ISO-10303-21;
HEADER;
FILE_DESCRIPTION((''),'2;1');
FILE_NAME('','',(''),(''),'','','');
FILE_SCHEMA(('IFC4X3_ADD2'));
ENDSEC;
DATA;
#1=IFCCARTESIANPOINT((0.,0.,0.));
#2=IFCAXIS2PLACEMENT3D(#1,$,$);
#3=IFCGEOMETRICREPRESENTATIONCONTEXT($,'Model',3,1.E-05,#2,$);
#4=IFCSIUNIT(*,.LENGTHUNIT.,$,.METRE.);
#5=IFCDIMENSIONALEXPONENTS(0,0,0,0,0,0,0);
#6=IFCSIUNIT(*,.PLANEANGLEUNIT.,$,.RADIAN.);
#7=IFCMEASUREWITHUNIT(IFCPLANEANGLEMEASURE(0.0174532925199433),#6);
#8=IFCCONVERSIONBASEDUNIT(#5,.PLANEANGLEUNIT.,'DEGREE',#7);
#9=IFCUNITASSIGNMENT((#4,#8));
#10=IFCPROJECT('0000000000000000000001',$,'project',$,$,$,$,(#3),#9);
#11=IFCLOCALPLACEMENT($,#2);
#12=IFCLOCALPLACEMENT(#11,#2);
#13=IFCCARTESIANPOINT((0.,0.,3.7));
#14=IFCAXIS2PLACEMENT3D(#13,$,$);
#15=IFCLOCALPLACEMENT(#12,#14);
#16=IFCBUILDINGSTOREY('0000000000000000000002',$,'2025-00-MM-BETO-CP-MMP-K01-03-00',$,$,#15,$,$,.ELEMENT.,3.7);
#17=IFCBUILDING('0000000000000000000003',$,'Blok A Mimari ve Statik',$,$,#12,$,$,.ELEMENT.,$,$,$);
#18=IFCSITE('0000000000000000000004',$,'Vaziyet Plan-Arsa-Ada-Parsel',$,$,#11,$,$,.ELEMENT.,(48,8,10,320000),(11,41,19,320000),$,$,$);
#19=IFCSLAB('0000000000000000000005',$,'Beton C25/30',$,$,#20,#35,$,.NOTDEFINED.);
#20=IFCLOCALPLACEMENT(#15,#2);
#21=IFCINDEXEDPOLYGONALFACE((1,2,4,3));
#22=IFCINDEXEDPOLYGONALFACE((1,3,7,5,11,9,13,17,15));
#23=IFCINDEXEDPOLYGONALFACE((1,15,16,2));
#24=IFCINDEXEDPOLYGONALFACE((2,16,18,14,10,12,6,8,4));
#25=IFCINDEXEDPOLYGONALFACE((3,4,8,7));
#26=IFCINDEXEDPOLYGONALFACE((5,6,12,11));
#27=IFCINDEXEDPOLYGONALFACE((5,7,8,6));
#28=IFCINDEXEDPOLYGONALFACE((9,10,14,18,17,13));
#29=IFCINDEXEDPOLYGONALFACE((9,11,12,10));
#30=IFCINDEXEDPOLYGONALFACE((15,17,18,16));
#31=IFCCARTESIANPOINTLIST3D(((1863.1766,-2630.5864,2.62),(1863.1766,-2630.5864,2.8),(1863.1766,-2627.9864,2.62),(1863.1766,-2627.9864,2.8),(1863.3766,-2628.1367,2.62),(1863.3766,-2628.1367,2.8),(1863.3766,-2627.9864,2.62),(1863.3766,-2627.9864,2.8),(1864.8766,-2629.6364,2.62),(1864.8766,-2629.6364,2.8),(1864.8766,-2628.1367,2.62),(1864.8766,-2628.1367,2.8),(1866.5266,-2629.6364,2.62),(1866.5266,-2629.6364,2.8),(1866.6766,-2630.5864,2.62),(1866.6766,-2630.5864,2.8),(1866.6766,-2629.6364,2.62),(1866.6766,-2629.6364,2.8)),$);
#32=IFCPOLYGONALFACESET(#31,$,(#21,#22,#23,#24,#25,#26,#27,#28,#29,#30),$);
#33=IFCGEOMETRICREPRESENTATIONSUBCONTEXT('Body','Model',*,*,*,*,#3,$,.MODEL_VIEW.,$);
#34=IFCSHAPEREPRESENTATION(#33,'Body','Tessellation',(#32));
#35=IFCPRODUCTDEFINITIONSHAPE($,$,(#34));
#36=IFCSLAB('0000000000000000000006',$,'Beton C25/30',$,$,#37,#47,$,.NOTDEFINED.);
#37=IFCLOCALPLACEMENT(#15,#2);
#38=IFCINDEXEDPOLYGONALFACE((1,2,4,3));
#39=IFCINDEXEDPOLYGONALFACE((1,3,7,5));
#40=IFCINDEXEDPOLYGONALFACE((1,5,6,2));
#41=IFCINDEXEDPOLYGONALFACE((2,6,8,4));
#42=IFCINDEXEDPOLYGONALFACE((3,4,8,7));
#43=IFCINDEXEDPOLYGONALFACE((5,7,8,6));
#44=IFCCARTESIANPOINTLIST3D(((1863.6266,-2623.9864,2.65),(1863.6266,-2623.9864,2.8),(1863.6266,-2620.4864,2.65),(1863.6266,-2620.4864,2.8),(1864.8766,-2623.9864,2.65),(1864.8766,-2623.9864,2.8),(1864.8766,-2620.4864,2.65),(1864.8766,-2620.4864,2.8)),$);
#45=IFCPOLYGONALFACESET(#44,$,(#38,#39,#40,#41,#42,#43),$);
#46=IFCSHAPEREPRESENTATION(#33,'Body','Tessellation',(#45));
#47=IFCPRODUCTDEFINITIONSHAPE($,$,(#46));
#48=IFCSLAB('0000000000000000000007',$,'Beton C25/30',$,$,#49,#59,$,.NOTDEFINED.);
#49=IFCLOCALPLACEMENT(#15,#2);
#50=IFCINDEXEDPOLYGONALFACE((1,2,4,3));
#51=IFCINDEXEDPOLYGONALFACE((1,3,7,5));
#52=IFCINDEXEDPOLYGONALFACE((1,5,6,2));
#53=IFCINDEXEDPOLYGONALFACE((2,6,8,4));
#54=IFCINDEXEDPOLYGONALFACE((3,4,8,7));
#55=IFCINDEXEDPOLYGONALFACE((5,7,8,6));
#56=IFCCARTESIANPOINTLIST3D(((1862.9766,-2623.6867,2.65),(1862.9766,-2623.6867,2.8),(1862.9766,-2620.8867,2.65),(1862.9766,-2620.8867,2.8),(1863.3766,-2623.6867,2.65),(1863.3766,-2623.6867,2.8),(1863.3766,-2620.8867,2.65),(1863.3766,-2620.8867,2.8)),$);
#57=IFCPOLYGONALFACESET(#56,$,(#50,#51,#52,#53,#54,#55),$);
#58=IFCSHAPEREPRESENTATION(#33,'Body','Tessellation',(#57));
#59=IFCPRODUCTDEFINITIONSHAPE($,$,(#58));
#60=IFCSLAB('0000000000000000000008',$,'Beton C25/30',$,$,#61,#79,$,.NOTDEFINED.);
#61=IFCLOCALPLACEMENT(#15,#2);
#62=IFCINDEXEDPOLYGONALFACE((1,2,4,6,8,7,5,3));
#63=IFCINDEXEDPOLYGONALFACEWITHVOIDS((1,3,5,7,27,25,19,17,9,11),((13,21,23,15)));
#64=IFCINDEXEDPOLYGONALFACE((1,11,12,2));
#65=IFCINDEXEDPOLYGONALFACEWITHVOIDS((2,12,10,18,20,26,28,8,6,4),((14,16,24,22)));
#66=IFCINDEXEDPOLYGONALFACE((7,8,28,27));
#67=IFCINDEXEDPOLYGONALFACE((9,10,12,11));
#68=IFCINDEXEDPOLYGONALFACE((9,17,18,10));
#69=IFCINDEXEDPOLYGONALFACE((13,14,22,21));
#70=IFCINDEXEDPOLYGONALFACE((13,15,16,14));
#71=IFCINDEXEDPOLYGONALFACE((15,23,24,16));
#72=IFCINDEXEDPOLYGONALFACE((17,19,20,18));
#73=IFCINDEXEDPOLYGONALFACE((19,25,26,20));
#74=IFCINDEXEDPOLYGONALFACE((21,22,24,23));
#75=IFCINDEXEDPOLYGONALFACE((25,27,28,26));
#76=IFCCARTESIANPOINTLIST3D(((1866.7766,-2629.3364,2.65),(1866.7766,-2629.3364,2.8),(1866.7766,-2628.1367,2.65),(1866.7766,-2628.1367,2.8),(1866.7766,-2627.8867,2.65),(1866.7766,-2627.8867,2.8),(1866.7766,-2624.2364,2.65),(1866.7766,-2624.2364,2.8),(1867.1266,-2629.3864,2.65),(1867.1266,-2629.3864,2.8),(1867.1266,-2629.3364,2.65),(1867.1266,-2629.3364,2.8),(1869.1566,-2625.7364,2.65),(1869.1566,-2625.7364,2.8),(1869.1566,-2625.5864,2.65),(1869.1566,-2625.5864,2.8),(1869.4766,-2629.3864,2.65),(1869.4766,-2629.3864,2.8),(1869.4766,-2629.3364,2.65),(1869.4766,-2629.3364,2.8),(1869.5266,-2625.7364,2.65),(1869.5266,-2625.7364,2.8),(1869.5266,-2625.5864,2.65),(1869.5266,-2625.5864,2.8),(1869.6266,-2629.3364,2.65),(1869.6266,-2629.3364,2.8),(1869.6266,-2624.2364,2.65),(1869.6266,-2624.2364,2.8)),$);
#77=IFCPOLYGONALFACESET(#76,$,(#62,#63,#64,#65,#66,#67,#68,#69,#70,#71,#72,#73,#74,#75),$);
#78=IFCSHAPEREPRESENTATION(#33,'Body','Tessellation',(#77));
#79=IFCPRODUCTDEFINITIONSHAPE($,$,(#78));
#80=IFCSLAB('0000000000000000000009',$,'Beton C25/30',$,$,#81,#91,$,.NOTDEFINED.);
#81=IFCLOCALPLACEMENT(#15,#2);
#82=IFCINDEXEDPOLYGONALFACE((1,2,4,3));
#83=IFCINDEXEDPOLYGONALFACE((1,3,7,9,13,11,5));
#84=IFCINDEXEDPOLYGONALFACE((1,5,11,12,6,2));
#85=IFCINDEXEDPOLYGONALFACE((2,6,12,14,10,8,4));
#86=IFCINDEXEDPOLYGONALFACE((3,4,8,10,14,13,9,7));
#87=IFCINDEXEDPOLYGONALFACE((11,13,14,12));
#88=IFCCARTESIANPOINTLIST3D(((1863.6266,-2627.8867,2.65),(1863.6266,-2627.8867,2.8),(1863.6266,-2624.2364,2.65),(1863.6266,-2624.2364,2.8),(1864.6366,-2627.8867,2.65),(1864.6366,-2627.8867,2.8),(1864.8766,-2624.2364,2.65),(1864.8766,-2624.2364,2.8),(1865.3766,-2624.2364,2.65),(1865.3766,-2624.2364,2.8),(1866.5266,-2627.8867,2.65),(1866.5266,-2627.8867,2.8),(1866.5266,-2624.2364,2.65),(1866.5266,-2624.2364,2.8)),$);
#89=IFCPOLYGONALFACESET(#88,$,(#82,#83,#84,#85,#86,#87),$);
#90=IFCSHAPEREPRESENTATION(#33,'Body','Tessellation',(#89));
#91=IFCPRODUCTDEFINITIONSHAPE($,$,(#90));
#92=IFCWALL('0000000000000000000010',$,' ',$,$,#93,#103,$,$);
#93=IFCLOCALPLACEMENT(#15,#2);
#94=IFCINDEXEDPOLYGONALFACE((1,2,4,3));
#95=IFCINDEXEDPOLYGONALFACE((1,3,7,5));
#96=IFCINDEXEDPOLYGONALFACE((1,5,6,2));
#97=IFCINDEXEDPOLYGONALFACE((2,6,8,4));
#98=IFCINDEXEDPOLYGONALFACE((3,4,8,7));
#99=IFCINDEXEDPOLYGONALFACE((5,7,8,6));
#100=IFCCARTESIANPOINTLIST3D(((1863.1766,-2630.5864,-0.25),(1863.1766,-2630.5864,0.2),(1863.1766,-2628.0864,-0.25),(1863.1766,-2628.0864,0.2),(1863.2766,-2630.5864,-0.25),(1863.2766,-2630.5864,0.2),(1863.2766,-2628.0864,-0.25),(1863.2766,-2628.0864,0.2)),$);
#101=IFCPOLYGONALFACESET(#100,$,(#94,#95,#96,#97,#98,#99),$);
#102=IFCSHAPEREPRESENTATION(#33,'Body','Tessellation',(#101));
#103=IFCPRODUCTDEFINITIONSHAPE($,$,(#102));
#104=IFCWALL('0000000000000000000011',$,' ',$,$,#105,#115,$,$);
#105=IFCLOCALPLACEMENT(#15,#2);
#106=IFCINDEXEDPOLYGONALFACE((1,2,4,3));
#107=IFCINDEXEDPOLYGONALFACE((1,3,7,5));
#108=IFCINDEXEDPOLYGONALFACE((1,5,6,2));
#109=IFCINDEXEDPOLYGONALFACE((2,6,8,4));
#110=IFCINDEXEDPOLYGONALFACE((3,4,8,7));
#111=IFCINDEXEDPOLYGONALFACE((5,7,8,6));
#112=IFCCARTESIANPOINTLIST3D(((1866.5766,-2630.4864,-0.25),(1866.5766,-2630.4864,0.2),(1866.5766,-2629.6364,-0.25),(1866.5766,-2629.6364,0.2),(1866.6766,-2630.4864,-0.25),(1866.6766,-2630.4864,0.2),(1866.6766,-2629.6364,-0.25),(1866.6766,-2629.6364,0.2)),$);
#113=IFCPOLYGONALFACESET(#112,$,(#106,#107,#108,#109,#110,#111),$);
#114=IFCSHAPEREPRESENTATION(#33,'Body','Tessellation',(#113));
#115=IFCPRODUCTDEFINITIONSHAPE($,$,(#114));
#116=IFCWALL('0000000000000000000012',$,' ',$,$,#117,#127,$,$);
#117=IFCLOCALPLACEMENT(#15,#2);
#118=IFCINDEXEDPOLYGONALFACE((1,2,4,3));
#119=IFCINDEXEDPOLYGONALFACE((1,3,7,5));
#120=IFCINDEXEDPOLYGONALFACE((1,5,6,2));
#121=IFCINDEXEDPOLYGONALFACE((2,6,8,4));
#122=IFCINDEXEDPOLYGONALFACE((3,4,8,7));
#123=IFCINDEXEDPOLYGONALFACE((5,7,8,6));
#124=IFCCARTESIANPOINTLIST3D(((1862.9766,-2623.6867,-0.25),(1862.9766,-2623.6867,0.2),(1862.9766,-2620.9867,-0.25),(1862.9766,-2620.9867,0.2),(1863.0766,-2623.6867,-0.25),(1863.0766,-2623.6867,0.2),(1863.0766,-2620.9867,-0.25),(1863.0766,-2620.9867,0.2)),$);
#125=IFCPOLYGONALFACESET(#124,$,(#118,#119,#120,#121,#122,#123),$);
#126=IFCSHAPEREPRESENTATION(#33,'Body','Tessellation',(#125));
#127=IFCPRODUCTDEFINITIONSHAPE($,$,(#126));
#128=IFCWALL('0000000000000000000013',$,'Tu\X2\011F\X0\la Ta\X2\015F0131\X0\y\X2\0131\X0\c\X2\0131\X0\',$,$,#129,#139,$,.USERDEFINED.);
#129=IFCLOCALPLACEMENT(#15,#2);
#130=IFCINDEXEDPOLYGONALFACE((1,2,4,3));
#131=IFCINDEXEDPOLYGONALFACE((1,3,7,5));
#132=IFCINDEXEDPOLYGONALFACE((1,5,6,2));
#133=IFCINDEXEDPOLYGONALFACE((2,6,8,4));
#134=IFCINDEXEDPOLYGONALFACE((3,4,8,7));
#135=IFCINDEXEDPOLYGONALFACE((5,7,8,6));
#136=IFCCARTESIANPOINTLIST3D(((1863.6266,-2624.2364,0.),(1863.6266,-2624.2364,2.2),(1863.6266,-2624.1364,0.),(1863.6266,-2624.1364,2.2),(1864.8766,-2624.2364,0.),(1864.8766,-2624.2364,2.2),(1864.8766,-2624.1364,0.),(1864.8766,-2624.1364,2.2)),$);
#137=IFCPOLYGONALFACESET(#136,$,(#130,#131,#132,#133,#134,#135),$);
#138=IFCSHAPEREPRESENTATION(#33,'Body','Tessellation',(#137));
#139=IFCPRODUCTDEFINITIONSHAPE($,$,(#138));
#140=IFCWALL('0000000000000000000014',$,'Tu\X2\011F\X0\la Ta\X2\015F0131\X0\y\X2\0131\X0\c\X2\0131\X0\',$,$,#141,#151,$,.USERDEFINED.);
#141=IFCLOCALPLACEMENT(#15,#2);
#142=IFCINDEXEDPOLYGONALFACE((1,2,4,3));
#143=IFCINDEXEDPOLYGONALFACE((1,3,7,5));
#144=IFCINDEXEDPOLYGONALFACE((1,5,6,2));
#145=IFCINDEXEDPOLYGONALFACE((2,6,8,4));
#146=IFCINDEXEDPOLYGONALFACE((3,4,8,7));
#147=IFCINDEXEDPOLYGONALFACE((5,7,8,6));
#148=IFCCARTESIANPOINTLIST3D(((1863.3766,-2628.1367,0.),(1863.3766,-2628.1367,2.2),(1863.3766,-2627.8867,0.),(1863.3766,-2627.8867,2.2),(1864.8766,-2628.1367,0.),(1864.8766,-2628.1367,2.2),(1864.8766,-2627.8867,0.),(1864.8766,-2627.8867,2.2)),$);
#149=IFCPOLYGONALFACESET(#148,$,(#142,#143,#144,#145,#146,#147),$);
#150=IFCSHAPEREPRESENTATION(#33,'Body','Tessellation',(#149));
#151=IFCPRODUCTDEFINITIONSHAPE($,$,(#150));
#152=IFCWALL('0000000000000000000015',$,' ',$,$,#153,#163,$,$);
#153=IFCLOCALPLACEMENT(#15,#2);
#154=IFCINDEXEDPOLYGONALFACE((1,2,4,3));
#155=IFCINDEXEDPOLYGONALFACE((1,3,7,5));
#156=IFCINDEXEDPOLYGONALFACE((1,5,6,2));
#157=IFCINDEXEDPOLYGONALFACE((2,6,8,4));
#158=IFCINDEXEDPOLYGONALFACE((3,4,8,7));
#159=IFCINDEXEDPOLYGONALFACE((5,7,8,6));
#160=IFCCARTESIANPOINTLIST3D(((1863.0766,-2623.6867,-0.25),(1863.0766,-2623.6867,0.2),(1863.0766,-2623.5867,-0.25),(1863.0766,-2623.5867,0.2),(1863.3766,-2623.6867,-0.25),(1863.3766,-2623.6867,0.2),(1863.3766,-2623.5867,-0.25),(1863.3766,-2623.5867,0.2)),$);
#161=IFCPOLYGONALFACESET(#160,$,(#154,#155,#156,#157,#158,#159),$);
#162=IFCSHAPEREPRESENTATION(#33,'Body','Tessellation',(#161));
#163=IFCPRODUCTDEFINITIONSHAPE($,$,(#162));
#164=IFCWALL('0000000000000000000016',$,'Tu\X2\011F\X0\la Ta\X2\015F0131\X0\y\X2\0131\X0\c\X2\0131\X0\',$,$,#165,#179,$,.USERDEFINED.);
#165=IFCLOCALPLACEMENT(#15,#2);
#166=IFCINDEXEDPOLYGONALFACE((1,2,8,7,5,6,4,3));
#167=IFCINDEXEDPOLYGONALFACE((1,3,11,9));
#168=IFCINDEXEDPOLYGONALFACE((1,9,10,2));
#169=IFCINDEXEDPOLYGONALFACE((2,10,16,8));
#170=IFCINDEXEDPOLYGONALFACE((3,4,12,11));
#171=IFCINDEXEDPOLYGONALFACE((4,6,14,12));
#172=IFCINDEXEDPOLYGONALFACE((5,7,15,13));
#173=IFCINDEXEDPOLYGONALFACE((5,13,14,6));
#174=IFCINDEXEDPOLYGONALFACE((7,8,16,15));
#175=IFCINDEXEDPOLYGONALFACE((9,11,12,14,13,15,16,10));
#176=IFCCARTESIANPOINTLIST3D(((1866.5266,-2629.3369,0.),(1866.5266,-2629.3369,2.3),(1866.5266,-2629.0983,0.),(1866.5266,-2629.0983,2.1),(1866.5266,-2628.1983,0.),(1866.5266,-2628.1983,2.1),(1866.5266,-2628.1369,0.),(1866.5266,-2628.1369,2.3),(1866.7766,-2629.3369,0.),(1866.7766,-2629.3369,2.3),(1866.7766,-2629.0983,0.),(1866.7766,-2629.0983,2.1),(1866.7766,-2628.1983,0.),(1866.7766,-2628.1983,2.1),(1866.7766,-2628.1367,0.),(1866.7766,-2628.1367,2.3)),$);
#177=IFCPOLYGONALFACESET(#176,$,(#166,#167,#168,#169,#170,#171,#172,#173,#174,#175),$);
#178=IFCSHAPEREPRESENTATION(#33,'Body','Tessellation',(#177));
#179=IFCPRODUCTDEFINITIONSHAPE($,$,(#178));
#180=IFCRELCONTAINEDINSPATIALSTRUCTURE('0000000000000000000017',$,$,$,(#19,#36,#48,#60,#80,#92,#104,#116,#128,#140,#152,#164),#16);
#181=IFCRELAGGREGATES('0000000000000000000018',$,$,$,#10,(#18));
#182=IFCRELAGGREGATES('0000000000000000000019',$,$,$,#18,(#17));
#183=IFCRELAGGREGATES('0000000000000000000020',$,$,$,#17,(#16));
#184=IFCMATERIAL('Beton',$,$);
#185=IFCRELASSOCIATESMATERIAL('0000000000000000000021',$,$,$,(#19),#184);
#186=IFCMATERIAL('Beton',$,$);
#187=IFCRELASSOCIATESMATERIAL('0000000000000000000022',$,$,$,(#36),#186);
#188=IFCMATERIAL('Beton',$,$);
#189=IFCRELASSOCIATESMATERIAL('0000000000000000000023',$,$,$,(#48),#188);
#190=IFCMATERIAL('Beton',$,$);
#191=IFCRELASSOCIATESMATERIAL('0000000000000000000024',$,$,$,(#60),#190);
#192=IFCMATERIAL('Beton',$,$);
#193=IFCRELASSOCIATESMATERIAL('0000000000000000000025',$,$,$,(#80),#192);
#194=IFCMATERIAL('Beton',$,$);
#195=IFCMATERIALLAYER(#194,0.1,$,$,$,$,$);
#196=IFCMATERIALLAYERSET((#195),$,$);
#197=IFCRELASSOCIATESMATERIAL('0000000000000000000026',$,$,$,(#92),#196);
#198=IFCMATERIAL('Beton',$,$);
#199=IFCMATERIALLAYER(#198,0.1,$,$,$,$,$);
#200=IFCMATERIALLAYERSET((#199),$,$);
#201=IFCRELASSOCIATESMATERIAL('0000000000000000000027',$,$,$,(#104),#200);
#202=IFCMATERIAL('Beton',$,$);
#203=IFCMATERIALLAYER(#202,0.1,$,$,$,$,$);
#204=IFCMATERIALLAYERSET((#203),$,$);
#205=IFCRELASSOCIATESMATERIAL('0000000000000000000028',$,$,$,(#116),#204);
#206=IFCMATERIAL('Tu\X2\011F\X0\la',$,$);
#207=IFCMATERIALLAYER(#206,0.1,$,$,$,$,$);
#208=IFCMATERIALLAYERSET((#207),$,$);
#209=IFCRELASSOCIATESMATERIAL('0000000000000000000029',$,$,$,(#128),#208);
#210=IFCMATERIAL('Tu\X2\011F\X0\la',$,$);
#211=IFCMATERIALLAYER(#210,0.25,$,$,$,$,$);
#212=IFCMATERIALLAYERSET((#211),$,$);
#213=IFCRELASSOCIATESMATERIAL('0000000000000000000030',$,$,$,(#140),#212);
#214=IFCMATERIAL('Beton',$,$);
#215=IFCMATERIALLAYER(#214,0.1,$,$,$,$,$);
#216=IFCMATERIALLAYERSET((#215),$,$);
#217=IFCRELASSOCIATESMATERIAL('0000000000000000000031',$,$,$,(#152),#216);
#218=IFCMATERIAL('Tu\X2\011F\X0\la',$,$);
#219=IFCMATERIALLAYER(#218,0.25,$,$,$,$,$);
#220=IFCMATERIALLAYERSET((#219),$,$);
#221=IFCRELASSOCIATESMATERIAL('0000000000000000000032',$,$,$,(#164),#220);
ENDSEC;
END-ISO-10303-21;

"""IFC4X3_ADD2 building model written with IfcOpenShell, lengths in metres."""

from ifc_helpers import new_model, entity, si_unit, converted_unit, frame, frame_2d, origin, origin_with_axes, place, context, subcontext, project, spatial, polyline, rectangle, outline, extrude, material, layer, layer_set, layer_usage, element, save


model = new_model("IFC4X3_ADD2")

# Units and contexts
model_context = context("Model", 3, precision=1e-05, world=origin())
body_context = subcontext(model_context, "Body", "Model", "MODEL_VIEW")
ifc_project = project(units=[si_unit("LENGTHUNIT", "METRE"), converted_unit("PLANEANGLEUNIT", "DEGREE", entity("IfcPlaneAngleMeasure", 0.0174532925199433), si_unit("PLANEANGLEUNIT", "RADIAN"), dimensions=[0, 0, 0, 0, 0, 0, 0])], contexts=[model_context])

# Site, building, storey
site_placement = place(None, origin())
site = spatial("IfcSite", under=ifc_project, at=site_placement, Name="Vaziyet Plan-Arsa-Ada-Parsel", CompositionType="ELEMENT", RefLatitude=(48, 8, 10, 320000), RefLongitude=(11, 41, 19, 320000))
building_placement = place(site_placement, origin())
building = spatial("IfcBuilding", under=site, at=building_placement, Name="Blok A Mimari ve Statik", CompositionType="ELEMENT")
storey_placement = place(building_placement, frame((0.0, 0.0, 3.7)))
storey = spatial("IfcBuildingStorey", under=building, at=storey_placement, Name="2025-00-MM-BETO-CP-MMP-K01-03-00", CompositionType="ELEMENT", Elevation=3.7)

# Slabs
ifc_material_1 = material(Name="Beton")
slab_1_placement = place(storey_placement, frame((1863.1766, -2630.5864, 2.62)))
element("IfcSlab", 1, at=slab_1_placement, inside=storey, material=ifc_material_1, Name="Beton C25/30", PredefinedType="NOTDEFINED", context=body_context, shape_type="SweptSolid", body=[
    extrude(outline(polyline([(1.7, 0.95), (1.7, 2.4497), (0.2, 2.4497), (0.2, 2.6), (0.0, 2.6), (0.0, 0.0), (3.5, 0.0), (3.5, 0.95), (3.35, 0.95), (1.7, 0.95)])), origin_with_axes(), (0.0, 0.0, 1.0), 0.18),
])
ifc_material_2 = material(Name="Beton")
slab_2_placement = place(storey_placement, frame((1863.6266, -2623.9864, 2.65)))
element("IfcSlab", 2, at=slab_2_placement, inside=storey, material=ifc_material_2, Name="Beton C25/30", PredefinedType="NOTDEFINED", context=body_context, shape_type="SweptSolid", body=[
    extrude(rectangle(XDim=3.5, YDim=1.25, at=frame_2d((0.625, -1.75), x_axis=(0.0, -1.0))), frame((0.0, 3.5, 0.0), z_axis=(0.0, 0.0, 1.0), x_axis=(1.0, 0.0, 0.0)), (0.0, 0.0, 1.0), 0.15),
])
ifc_material_3 = material(Name="Beton")
slab_3_placement = place(storey_placement, frame((1862.9766, -2623.6867, 2.65)))
element("IfcSlab", 3, at=slab_3_placement, inside=storey, material=ifc_material_3, Name="Beton C25/30", PredefinedType="NOTDEFINED", context=body_context, shape_type="SweptSolid", body=[
    extrude(rectangle(XDim=2.8, YDim=0.4, at=frame_2d((0.2, -1.4), x_axis=(0.0, -1.0))), frame((0.0, 2.8, 0.0), z_axis=(0.0, 0.0, 1.0), x_axis=(1.0, 0.0, 0.0)), (0.0, 0.0, 1.0), 0.15),
])
ifc_material_4 = material(Name="Beton")
slab_4_placement = place(storey_placement, frame((1866.7766, -2629.3864, 2.65)))
element("IfcSlab", 4, at=slab_4_placement, inside=storey, material=ifc_material_4, Name="Beton C25/30", PredefinedType="NOTDEFINED", context=body_context, shape_type="SweptSolid", body=[
    extrude(outline(polyline([(0.0, 5.15), (0.0, 1.4997), (0.0, 1.2497), (0.0, 0.05), (0.35, 0.05), (0.35, 0.0), (2.7, 0.0), (2.7, 0.05), (2.85, 0.05), (2.85, 5.15), (0.0, 5.15)]), holes=[polyline([(2.38, 3.8), (2.75, 3.8), (2.75, 3.65), (2.38, 3.65), (2.38, 3.8)])]), origin_with_axes(), (0.0, 0.0, 1.0), 0.15),
])
ifc_material_5 = material(Name="Beton")
slab_5_placement = place(storey_placement, frame((1863.6266, -2627.8867, 2.65)))
element("IfcSlab", 5, at=slab_5_placement, inside=storey, material=ifc_material_5, Name="Beton C25/30", PredefinedType="NOTDEFINED", context=body_context, shape_type="SweptSolid", body=[
    extrude(outline(polyline([(1.25, 3.6503), (0.0, 3.6503), (0.0, 0.0), (1.01, 0.0), (2.9, 0.0), (2.9, 3.6503), (1.75, 3.6503), (1.25, 3.6503)])), origin_with_axes(), (0.0, 0.0, 1.0), 0.15),
])

# Walls
ifc_material_6 = material(Name="Beton")
ifc_layer_1 = layer(ifc_material_6, 0.1)
ifc_layer_set_1 = layer_set([ifc_layer_1])
ifc_layer_usage_1 = layer_usage(ifc_layer_set_1, "AXIS2", "POSITIVE", 0.0)
wall_1_placement = place(storey_placement, frame((1863.1766, -2628.0864, -0.25), z_axis=(0.0, 0.0, 1.0), x_axis=(0.0, -1.0, 0.0)))
element("IfcWall", 6, at=wall_1_placement, inside=storey, material=ifc_layer_usage_1, Name=" ", context=body_context, shape_type="SweptSolid", body=[
    extrude(rectangle(XDim=2.5, YDim=0.1, at=frame_2d((1.25, 0.05), x_axis=(1.0, 0.0))), origin_with_axes(), (0.0, 0.0, 1.0), 0.45),
])
ifc_material_7 = material(Name="Beton")
ifc_layer_2 = layer(ifc_material_7, 0.1)
ifc_layer_set_2 = layer_set([ifc_layer_2])
ifc_layer_usage_2 = layer_usage(ifc_layer_set_2, "AXIS2", "POSITIVE", 0.0)
wall_2_placement = place(storey_placement, frame((1866.6766, -2630.4864, -0.25), z_axis=(0.0, 0.0, 1.0), x_axis=(0.0, 1.0, 0.0)))
element("IfcWall", 7, at=wall_2_placement, inside=storey, material=ifc_layer_usage_2, Name=" ", context=body_context, shape_type="SweptSolid", body=[
    extrude(rectangle(XDim=0.85, YDim=0.1, at=frame_2d((0.425, 0.05), x_axis=(1.0, 0.0))), origin_with_axes(), (0.0, 0.0, 1.0), 0.45),
])
ifc_material_8 = material(Name="Beton")
ifc_layer_3 = layer(ifc_material_8, 0.1)
ifc_layer_set_3 = layer_set([ifc_layer_3])
ifc_layer_usage_3 = layer_usage(ifc_layer_set_3, "AXIS2", "POSITIVE", 0.0)
wall_3_placement = place(storey_placement, frame((1862.9766, -2620.9867, -0.25), z_axis=(0.0, 0.0, 1.0), x_axis=(0.0, -1.0, 0.0)))
element("IfcWall", 8, at=wall_3_placement, inside=storey, material=ifc_layer_usage_3, Name=" ", context=body_context, shape_type="SweptSolid", body=[
    extrude(rectangle(XDim=2.7, YDim=0.1, at=frame_2d((1.35, 0.05), x_axis=(1.0, 0.0))), origin_with_axes(), (0.0, 0.0, 1.0), 0.45),
])
ifc_material_9 = material(Name="Tuğla")
ifc_layer_4 = layer(ifc_material_9, 0.1)
ifc_layer_set_4 = layer_set([ifc_layer_4])
ifc_layer_usage_4 = layer_usage(ifc_layer_set_4, "AXIS2", "POSITIVE", 0.0)
wall_4_placement = place(storey_placement, frame((1863.6266, -2624.2364, 0.0), z_axis=(0.0, 0.0, 1.0), x_axis=(1.0, 0.000002, 0.0)))
element("IfcWall", 9, at=wall_4_placement, inside=storey, material=ifc_layer_usage_4, Name="Tuğla Taşıyıcı", PredefinedType="USERDEFINED", context=body_context, shape_type="SweptSolid", body=[
    extrude(rectangle(XDim=1.25, YDim=0.1, at=frame_2d((0.625, 0.05), x_axis=(1.0, 0.0))), origin_with_axes(), (0.0, 0.0, 1.0), 2.2),
])
ifc_material_10 = material(Name="Tuğla")
ifc_layer_5 = layer(ifc_material_10, 0.25)
ifc_layer_set_5 = layer_set([ifc_layer_5])
ifc_layer_usage_5 = layer_usage(ifc_layer_set_5, "AXIS2", "POSITIVE", 0.0)
wall_5_placement = place(storey_placement, frame((1863.3766, -2628.1367, 0.0)))
element("IfcWall", 10, at=wall_5_placement, inside=storey, material=ifc_layer_usage_5, Name="Tuğla Taşıyıcı", PredefinedType="USERDEFINED", context=body_context, shape_type="SweptSolid", body=[
    extrude(rectangle(XDim=1.5, YDim=0.25, at=frame_2d((0.75, 0.125), x_axis=(1.0, 0.0))), origin_with_axes(), (0.0, 0.0, 1.0), 2.2),
])
ifc_material_11 = material(Name="Beton")
ifc_layer_6 = layer(ifc_material_11, 0.1)
ifc_layer_set_6 = layer_set([ifc_layer_6])
ifc_layer_usage_6 = layer_usage(ifc_layer_set_6, "AXIS2", "POSITIVE", 0.0)
wall_6_placement = place(storey_placement, frame((1863.0766, -2623.6867, -0.25)))
element("IfcWall", 11, at=wall_6_placement, inside=storey, material=ifc_layer_usage_6, Name=" ", context=body_context, shape_type="SweptSolid", body=[
    extrude(rectangle(XDim=0.3, YDim=0.1, at=frame_2d((0.15, 0.05), x_axis=(1.0, 0.0))), origin_with_axes(), (0.0, 0.0, 1.0), 0.45),
])

# Wall, opening
ifc_material_12 = material(Name="Tuğla")
ifc_layer_7 = layer(ifc_material_12, 0.25)
ifc_layer_set_7 = layer_set([ifc_layer_7])
ifc_layer_usage_7 = layer_usage(ifc_layer_set_7, "AXIS2", "POSITIVE", 0.0)
wall_7_placement = place(storey_placement, frame((1866.5266, -2628.1369, 0.0), z_axis=(0.0, 0.0, 1.0), x_axis=(0.0, -1.0, 0.0)))
wall_7 = element("IfcWall", 12, at=wall_7_placement, inside=storey, material=ifc_layer_usage_7, Name="Tuğla Taşıyıcı", PredefinedType="USERDEFINED", context=body_context, shape_type="SweptSolid", body=[
    extrude(outline(polyline([(-1.2, 0.0), (0.0, 0.0), (0.0, 0.25), (-1.2001, 0.25), (-1.2, 0.0)])), frame((1.2, 0.0, 0.0), z_axis=(0.0, 0.0, 1.0), x_axis=(1.0, 0.0, 0.0)), (0.0, 0.0, 1.0), 2.3),
])
opening_1_placement = place(wall_7_placement, frame((0.0614, 0.0, 0.0), z_axis=(0.0, 1.0, 0.0), x_axis=(0.0, 0.0, 1.0)))
element("IfcOpeningElement", 13, at=opening_1_placement, cuts=wall_7, PredefinedType="OPENING", context=body_context, shape_type="SweptSolid", body=[
    extrude(outline(polyline([(2.1, 0.9), (2.1, 0.0), (0.0, 0.0), (0.0, 0.9), (2.1, 0.9)])), origin_with_axes(), (0.0, 0.0, 1.0), 0.25),
])

save(model, "model.ifc")
